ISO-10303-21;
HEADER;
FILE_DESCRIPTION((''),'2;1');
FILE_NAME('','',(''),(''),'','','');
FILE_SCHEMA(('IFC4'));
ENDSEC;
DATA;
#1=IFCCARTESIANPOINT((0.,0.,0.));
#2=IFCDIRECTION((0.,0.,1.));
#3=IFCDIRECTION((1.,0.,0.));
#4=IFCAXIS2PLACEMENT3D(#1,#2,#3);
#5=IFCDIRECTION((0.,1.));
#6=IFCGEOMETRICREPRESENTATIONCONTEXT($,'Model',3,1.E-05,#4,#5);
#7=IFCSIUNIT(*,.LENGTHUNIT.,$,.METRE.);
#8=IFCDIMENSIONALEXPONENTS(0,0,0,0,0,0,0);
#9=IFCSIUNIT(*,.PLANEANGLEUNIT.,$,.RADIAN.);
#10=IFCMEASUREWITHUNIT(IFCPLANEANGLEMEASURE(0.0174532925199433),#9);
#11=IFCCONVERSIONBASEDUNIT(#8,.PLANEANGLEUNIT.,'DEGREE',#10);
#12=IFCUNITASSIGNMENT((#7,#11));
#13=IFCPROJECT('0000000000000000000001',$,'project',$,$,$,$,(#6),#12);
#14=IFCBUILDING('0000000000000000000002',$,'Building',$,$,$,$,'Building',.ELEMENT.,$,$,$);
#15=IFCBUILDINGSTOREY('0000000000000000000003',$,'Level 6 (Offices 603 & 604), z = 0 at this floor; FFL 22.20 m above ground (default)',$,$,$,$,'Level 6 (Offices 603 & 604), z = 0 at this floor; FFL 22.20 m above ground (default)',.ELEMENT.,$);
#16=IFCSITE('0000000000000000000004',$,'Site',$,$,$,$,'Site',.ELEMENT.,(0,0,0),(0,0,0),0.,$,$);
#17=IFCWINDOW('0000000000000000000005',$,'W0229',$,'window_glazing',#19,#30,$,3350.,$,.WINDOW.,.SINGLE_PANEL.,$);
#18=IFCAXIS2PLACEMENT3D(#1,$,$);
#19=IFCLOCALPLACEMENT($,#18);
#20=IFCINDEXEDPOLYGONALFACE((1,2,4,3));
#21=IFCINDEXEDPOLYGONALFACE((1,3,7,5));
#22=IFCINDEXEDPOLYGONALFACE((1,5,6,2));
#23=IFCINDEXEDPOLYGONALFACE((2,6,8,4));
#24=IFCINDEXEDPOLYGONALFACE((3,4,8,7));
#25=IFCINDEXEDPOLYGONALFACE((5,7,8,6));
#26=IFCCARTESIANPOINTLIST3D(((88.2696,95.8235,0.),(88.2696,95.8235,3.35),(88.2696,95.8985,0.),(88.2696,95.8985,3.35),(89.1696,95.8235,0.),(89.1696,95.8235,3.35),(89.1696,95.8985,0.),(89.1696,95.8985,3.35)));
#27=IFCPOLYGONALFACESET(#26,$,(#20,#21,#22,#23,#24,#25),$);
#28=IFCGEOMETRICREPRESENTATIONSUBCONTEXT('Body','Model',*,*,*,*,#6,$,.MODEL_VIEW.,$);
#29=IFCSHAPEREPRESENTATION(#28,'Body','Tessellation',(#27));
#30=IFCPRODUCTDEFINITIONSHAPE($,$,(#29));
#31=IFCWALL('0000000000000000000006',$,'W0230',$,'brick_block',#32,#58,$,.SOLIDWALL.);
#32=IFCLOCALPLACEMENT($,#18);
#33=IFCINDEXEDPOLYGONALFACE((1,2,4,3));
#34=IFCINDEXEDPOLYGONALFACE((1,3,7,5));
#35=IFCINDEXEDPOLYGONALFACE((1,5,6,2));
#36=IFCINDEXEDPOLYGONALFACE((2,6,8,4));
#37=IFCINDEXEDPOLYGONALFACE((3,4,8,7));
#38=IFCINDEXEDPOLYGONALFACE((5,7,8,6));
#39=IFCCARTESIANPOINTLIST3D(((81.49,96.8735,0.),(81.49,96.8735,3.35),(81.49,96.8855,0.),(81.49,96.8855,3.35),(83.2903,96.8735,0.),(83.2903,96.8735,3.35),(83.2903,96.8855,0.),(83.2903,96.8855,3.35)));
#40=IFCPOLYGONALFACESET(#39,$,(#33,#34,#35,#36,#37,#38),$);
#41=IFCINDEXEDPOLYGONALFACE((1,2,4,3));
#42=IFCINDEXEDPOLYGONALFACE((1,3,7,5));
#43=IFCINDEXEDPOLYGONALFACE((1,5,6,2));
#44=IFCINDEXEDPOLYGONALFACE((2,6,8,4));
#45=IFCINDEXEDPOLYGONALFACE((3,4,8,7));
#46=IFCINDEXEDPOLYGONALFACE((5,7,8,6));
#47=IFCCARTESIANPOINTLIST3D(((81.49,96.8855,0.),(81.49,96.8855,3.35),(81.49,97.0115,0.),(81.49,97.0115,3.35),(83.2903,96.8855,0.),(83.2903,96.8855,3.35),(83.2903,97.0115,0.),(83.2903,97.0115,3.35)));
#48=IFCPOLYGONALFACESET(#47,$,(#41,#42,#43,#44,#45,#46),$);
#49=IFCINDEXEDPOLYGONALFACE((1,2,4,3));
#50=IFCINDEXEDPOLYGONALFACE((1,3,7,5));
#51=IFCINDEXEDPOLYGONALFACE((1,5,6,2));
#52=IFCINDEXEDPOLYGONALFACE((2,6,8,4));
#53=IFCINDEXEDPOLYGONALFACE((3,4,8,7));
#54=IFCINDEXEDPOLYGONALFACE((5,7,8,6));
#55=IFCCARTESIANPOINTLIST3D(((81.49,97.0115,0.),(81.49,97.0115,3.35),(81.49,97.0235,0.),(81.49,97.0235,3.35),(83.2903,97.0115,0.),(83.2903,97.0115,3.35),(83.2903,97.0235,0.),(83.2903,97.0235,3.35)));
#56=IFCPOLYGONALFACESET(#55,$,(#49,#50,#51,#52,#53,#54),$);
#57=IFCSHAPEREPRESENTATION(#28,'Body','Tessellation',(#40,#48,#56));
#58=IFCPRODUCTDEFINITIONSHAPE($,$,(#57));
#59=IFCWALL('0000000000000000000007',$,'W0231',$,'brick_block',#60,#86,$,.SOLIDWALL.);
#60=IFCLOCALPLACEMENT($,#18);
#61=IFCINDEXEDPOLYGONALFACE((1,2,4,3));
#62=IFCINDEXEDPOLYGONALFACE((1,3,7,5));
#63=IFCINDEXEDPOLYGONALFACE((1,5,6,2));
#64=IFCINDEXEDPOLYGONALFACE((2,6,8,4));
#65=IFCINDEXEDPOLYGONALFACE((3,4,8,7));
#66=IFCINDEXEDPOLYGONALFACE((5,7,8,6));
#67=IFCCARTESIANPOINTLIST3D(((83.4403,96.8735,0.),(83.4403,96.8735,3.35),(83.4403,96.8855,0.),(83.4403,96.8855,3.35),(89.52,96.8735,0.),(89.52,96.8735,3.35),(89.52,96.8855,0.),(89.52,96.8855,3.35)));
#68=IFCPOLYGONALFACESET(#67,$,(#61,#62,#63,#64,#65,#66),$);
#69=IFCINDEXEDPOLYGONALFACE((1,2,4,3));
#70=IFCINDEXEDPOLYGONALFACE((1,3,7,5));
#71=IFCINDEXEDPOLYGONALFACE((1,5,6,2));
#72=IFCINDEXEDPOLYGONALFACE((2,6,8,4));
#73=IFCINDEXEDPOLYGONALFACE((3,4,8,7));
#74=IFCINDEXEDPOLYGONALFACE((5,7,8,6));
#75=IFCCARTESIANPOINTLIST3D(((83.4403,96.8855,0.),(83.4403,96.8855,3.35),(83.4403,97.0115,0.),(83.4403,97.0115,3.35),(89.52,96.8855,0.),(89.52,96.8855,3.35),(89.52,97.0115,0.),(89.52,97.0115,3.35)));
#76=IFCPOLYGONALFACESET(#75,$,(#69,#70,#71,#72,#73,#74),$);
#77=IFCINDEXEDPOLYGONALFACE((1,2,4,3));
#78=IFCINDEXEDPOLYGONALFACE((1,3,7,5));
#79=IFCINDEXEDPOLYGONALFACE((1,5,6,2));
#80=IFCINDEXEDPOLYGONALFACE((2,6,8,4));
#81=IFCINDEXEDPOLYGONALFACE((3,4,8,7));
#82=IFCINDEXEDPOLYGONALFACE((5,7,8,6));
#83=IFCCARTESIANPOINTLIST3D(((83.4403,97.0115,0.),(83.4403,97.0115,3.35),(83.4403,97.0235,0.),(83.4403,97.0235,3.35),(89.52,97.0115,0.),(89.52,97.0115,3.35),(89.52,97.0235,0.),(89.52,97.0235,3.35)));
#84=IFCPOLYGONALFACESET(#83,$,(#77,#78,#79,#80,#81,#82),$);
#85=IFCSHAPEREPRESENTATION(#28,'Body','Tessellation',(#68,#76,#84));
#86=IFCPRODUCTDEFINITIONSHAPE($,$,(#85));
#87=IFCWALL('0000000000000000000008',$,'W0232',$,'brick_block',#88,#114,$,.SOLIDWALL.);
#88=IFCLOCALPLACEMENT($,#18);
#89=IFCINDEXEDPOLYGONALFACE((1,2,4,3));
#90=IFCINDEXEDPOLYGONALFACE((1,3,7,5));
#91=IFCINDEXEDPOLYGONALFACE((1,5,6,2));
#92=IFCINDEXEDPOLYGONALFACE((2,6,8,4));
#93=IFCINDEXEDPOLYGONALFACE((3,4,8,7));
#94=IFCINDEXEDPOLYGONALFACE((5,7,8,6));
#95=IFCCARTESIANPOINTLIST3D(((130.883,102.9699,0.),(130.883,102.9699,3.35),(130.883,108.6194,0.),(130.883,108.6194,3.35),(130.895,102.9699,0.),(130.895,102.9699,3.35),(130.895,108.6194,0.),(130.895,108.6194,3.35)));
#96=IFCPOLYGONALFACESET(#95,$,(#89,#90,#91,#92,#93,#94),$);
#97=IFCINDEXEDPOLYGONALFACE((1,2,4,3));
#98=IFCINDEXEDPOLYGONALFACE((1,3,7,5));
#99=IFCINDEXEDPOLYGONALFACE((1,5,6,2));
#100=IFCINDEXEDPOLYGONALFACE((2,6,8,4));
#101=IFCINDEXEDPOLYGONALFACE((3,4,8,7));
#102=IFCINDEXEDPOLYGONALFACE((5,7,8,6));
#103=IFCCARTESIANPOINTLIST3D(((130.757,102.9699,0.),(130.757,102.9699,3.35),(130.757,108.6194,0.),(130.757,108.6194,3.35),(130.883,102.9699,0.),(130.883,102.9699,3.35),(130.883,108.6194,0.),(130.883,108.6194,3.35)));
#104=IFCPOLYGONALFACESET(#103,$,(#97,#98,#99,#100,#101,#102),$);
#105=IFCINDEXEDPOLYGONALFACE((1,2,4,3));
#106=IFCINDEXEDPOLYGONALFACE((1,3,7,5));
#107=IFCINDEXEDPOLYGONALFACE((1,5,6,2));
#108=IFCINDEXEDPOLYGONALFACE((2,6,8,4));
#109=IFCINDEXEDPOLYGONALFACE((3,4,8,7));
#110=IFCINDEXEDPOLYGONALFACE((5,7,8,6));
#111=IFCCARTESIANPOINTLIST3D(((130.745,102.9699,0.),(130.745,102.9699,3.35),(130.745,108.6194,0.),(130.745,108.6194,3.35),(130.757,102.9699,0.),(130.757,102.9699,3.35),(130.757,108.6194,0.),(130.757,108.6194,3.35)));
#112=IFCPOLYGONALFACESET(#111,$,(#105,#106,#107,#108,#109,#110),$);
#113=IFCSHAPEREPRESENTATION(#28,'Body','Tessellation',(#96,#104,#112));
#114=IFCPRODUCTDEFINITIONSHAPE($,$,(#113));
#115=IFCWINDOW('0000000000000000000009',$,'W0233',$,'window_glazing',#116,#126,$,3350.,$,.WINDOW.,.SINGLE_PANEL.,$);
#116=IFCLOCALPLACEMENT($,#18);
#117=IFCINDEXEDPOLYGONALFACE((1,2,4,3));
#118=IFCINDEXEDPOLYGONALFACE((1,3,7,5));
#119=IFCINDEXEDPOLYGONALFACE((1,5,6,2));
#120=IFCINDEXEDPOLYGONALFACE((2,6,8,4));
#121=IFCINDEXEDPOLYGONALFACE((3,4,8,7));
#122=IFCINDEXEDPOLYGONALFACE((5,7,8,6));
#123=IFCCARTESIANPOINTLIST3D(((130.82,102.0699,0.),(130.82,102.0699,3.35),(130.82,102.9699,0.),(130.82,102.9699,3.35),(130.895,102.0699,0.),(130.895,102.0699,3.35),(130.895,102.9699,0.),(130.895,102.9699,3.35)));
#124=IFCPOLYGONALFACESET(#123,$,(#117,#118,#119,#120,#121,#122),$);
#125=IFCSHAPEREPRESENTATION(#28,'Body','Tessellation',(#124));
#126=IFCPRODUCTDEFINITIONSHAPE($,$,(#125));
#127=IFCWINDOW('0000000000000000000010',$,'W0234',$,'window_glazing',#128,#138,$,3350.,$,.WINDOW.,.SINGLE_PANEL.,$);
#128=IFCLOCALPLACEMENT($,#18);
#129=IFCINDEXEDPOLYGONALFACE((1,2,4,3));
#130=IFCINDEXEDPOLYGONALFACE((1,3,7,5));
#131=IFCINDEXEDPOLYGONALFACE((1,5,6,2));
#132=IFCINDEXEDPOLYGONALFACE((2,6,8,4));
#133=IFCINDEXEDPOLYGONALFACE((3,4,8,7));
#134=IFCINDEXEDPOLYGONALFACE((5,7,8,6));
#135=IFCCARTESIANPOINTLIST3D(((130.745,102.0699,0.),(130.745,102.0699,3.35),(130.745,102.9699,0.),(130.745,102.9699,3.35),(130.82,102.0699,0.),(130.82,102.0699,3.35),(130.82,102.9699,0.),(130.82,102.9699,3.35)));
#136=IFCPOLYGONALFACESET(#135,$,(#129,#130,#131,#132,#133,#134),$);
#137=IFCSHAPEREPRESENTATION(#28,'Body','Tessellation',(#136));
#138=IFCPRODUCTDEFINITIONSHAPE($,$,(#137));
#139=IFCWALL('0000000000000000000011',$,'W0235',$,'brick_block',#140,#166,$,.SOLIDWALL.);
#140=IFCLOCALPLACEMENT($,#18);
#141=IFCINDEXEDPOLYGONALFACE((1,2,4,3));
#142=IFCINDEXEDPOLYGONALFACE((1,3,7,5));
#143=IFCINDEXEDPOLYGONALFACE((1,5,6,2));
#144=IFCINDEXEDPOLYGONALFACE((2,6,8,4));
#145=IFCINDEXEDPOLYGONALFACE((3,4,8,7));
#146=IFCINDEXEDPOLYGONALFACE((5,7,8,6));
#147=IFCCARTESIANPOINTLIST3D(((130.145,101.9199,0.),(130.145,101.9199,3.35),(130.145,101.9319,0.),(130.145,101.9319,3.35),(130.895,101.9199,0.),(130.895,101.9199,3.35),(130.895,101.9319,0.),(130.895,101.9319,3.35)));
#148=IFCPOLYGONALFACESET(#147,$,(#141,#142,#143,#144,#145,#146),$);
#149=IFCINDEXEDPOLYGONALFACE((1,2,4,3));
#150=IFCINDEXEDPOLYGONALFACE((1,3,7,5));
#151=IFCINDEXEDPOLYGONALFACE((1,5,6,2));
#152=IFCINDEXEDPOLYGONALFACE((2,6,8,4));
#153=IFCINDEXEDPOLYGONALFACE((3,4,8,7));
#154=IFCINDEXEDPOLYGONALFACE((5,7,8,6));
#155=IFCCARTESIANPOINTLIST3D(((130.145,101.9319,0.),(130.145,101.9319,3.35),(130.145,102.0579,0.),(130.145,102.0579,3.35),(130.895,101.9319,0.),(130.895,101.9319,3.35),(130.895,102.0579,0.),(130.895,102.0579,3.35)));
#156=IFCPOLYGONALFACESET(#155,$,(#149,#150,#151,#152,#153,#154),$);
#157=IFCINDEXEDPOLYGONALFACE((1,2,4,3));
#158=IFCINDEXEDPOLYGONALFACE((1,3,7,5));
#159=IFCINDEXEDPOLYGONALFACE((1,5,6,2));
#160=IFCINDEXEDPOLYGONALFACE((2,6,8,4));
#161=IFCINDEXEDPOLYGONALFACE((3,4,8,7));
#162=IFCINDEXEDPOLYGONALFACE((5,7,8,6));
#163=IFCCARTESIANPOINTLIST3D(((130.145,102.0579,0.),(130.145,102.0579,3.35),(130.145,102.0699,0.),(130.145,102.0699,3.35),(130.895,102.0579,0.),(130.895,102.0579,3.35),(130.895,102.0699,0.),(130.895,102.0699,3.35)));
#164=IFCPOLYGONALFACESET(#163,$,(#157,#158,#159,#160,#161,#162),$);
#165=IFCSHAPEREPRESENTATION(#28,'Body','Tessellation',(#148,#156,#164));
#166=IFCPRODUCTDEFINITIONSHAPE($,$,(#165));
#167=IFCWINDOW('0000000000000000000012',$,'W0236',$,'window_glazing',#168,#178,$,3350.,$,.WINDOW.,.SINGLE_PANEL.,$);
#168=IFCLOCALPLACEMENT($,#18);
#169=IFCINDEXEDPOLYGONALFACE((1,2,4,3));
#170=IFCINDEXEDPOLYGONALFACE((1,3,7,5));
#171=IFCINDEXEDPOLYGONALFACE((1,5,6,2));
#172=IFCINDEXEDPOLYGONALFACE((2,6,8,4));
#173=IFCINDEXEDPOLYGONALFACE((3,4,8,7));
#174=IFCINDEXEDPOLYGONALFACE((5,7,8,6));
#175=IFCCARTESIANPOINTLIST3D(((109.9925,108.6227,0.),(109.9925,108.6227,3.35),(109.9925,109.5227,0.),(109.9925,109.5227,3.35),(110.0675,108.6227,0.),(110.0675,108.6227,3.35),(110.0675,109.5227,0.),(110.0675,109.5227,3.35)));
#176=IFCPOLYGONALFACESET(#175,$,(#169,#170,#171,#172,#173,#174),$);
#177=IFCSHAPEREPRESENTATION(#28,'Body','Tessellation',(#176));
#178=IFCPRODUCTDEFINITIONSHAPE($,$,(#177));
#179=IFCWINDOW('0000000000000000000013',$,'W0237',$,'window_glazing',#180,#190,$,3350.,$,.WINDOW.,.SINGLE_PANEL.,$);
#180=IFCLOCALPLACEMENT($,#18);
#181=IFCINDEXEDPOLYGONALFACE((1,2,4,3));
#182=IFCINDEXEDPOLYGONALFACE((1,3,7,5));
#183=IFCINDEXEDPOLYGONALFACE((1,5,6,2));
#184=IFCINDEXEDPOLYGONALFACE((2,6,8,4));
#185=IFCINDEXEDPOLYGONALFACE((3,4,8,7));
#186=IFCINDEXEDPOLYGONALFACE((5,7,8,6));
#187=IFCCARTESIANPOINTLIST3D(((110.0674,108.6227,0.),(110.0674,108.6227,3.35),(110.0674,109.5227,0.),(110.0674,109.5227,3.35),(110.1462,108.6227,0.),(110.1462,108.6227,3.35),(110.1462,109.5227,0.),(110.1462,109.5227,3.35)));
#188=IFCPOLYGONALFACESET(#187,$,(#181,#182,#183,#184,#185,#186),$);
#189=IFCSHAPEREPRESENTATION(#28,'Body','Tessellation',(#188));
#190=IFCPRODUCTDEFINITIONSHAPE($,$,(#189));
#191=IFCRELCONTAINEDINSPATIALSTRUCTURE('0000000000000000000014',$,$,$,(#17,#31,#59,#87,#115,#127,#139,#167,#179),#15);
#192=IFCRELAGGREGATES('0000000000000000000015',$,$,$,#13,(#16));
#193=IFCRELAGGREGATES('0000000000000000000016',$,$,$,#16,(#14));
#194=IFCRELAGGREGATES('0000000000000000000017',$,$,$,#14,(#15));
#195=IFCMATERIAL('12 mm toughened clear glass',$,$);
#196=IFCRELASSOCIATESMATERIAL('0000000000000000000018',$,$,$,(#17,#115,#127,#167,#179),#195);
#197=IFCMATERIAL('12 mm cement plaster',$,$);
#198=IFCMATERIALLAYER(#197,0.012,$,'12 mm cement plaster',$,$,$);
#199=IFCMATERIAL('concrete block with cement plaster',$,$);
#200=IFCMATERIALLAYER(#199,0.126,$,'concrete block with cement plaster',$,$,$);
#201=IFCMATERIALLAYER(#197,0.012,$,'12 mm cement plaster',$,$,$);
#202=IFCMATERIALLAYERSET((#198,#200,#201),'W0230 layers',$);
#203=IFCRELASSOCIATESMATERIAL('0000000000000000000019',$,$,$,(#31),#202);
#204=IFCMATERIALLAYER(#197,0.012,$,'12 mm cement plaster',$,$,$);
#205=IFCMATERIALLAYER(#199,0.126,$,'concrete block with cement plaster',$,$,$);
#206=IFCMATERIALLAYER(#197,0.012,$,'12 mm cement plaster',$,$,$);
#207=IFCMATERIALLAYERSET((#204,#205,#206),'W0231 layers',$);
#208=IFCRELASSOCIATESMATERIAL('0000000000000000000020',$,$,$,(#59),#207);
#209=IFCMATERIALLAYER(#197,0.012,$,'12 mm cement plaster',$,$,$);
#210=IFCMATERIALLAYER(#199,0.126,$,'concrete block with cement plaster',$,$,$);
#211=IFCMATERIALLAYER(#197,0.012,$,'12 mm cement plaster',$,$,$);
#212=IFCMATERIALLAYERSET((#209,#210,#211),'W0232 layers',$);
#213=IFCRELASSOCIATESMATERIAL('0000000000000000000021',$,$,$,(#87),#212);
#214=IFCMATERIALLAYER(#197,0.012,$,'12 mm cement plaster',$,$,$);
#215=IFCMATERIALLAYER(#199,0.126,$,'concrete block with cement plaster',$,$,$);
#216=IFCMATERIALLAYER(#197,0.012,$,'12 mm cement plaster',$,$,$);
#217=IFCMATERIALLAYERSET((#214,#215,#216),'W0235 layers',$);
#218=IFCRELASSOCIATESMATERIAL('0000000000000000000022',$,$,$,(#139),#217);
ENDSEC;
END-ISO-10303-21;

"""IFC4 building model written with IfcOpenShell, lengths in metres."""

from ifc_helpers import new_model, entity, si_unit, converted_unit, direction, frame, frame_2d, origin_with_axes, origin_2d_with_axis, place, context, subcontext, project, spatial, rectangle, extrude, material, layer, layer_set, layer_usage, element, save


model = new_model("IFC4")

# Units and contexts
model_context = context("Model", 3, precision=1e-05, world=origin_with_axes(), true_north=direction((0.0, 1.0)))
body_context = subcontext(model_context, "Body", "Model", "MODEL_VIEW")
ifc_project = project(units=[si_unit("LENGTHUNIT", "METRE"), converted_unit("PLANEANGLEUNIT", "DEGREE", entity("IfcPlaneAngleMeasure", 0.0174532925199433), si_unit("PLANEANGLEUNIT", "RADIAN"), dimensions=[0, 0, 0, 0, 0, 0, 0])], contexts=[model_context])

# Site, building, storey
site = spatial("IfcSite", under=ifc_project, Name="Site", LongName="Site", CompositionType="ELEMENT", RefLatitude=(0, 0, 0), RefLongitude=(0, 0, 0), RefElevation=0.0)
building = spatial("IfcBuilding", under=site, Name="Building", LongName="Building", CompositionType="ELEMENT")
storey = spatial("IfcBuildingStorey", under=building, Name="Level 6 (Offices 603 & 604), z = 0 at this floor; FFL 22.20 m above ground (default)", LongName="Level 6 (Offices 603 & 604), z = 0 at this floor; FFL 22.20 m above ground (default)", CompositionType="ELEMENT")

# Shared definitions
ifc_material_1 = material(Name="12 mm toughened clear glass")
placement = place(None, origin_with_axes())

# Shared definitions
ifc_material_2 = material(Name="12 mm cement plaster")
ifc_material_3 = material(Name="concrete block with cement plaster")

# Window
element("IfcWindow", 1, at=placement, inside=storey, material=ifc_material_1, Name="W0229", ObjectType="window_glazing", OverallHeight=3350.0, PartitioningType="SINGLE_PANEL", PredefinedType="WINDOW", context=body_context, shape_type="SweptSolid", body=[
    extrude(rectangle(XDim=0.9, YDim=0.075, at=frame_2d((0.0, 0.0), x_axis=(1.0, 0.0))), frame((88.7196, 95.861, 0.0), z_axis=(0.0, 0.0, 1.0), x_axis=(1.0, 0.0, 0.0)), (0.0, 0.0, 1.0), 3.35),
])

# Walls
ifc_layer_1 = layer(ifc_material_2, 0.012, Name="12 mm cement plaster")
ifc_layer_2 = layer(ifc_material_3, 0.126, Name="concrete block with cement plaster")
ifc_layer_3 = layer(ifc_material_2, 0.012, Name="12 mm cement plaster")
ifc_layer_set_1 = layer_set([ifc_layer_1, ifc_layer_2, ifc_layer_3], Name="W0230 layers")
ifc_layer_usage_1 = layer_usage(ifc_layer_set_1, "AXIS2", "POSITIVE", -0.075)
element("IfcWall", 2, at=placement, inside=storey, material=ifc_layer_usage_1, Name="W0230", ObjectType="brick_block", PredefinedType="SOLIDWALL", context=body_context, shape_type="SweptSolid", body=[
    extrude(rectangle(XDim=1.8003, YDim=0.012, at=frame_2d((0.0, 0.0), x_axis=(1.0, 0.0))), frame((82.3902, 96.8795, 0.0), z_axis=(0.0, 0.0, 1.0), x_axis=(1.0, 0.0, 0.0)), (0.0, 0.0, 1.0), 3.35),
    extrude(rectangle(XDim=1.8003, YDim=0.126, at=frame_2d((0.0, 0.069), x_axis=(1.0, 0.0))), frame((82.3902, 96.8795, 0.0), z_axis=(0.0, 0.0, 1.0), x_axis=(1.0, 0.0, 0.0)), (0.0, 0.0, 1.0), 3.35),
    extrude(rectangle(XDim=1.8003, YDim=0.012, at=frame_2d((0.0, 0.138), x_axis=(1.0, 0.0))), frame((82.3902, 96.8795, 0.0), z_axis=(0.0, 0.0, 1.0), x_axis=(1.0, 0.0, 0.0)), (0.0, 0.0, 1.0), 3.35),
])
ifc_layer_4 = layer(ifc_material_2, 0.012, Name="12 mm cement plaster")
ifc_layer_5 = layer(ifc_material_3, 0.126, Name="concrete block with cement plaster")
ifc_layer_6 = layer(ifc_material_2, 0.012, Name="12 mm cement plaster")
ifc_layer_set_2 = layer_set([ifc_layer_4, ifc_layer_5, ifc_layer_6], Name="W0231 layers")
ifc_layer_usage_2 = layer_usage(ifc_layer_set_2, "AXIS2", "POSITIVE", -0.075)
element("IfcWall", 3, at=placement, inside=storey, material=ifc_layer_usage_2, Name="W0231", ObjectType="brick_block", PredefinedType="SOLIDWALL", context=body_context, shape_type="SweptSolid", body=[
    extrude(rectangle(XDim=6.0797, YDim=0.012, at=origin_2d_with_axis()), frame((86.4801, 96.8795, 0.0), z_axis=(0.0, 0.0, 1.0), x_axis=(1.0, 0.0, 0.0)), (0.0, 0.0, 1.0), 3.35),
    extrude(rectangle(XDim=6.0797, YDim=0.126, at=frame_2d((0.0, 0.069), x_axis=(1.0, 0.0))), frame((86.4801, 96.8795, 0.0), z_axis=(0.0, 0.0, 1.0), x_axis=(1.0, 0.0, 0.0)), (0.0, 0.0, 1.0), 3.35),
    extrude(rectangle(XDim=6.0797, YDim=0.012, at=frame_2d((0.0, 0.138), x_axis=(1.0, 0.0))), frame((86.4801, 96.8795, 0.0), z_axis=(0.0, 0.0, 1.0), x_axis=(1.0, 0.0, 0.0)), (0.0, 0.0, 1.0), 3.35),
])
ifc_layer_7 = layer(ifc_material_2, 0.012, Name="12 mm cement plaster")
ifc_layer_8 = layer(ifc_material_3, 0.126, Name="concrete block with cement plaster")
ifc_layer_9 = layer(ifc_material_2, 0.012, Name="12 mm cement plaster")
ifc_layer_set_3 = layer_set([ifc_layer_7, ifc_layer_8, ifc_layer_9], Name="W0232 layers")
ifc_layer_usage_3 = layer_usage(ifc_layer_set_3, "AXIS2", "POSITIVE", -0.075)
element("IfcWall", 4, at=placement, inside=storey, material=ifc_layer_usage_3, Name="W0232", ObjectType="brick_block", PredefinedType="SOLIDWALL", context=body_context, shape_type="SweptSolid", body=[
    extrude(rectangle(XDim=5.6495, YDim=0.012, at=frame_2d((0.0, 0.0), x_axis=(0.0, 1.0))), frame((130.889, 105.7947, 0.0), z_axis=(0.0, 0.0, 1.0), x_axis=(1.0, 0.0, 0.0)), (0.0, 0.0, 1.0), 3.35),
    extrude(rectangle(XDim=5.6495, YDim=0.126, at=frame_2d((-0.069, 0.0), x_axis=(0.0, 1.0))), frame((130.889, 105.7947, 0.0), z_axis=(0.0, 0.0, 1.0), x_axis=(1.0, 0.0, 0.0)), (0.0, 0.0, 1.0), 3.35),
    extrude(rectangle(XDim=5.6495, YDim=0.012, at=frame_2d((-0.138, 0.0), x_axis=(0.0, 1.0))), frame((130.889, 105.7947, 0.0), z_axis=(0.0, 0.0, 1.0), x_axis=(1.0, 0.0, 0.0)), (0.0, 0.0, 1.0), 3.35),
])

# Windows
element("IfcWindow", 5, at=placement, inside=storey, material=ifc_material_1, Name="W0233", ObjectType="window_glazing", OverallHeight=3350.0, PartitioningType="SINGLE_PANEL", PredefinedType="WINDOW", context=body_context, shape_type="SweptSolid", body=[
    extrude(rectangle(XDim=0.9, YDim=0.075, at=frame_2d((0.0, 0.0), x_axis=(0.0, 1.0))), frame((130.8575, 102.5199, 0.0), z_axis=(0.0, 0.0, 1.0), x_axis=(1.0, 0.0, 0.0)), (0.0, 0.0, 1.0), 3.35),
])
element("IfcWindow", 6, at=placement, inside=storey, material=ifc_material_1, Name="W0234", ObjectType="window_glazing", OverallHeight=3350.0, PartitioningType="SINGLE_PANEL", PredefinedType="WINDOW", context=body_context, shape_type="SweptSolid", body=[
    extrude(rectangle(XDim=0.9, YDim=0.075, at=frame_2d((0.0, 0.0), x_axis=(0.0, 1.0))), frame((130.7825, 102.5199, 0.0), z_axis=(0.0, 0.0, 1.0), x_axis=(1.0, 0.0, 0.0)), (0.0, 0.0, 1.0), 3.35),
])

# Wall
ifc_layer_10 = layer(ifc_material_2, 0.012, Name="12 mm cement plaster")
ifc_layer_11 = layer(ifc_material_3, 0.126, Name="concrete block with cement plaster")
ifc_layer_12 = layer(ifc_material_2, 0.012, Name="12 mm cement plaster")
ifc_layer_set_4 = layer_set([ifc_layer_10, ifc_layer_11, ifc_layer_12], Name="W0235 layers")
ifc_layer_usage_4 = layer_usage(ifc_layer_set_4, "AXIS2", "POSITIVE", -0.075)
element("IfcWall", 7, at=placement, inside=storey, material=ifc_layer_usage_4, Name="W0235", ObjectType="brick_block", PredefinedType="SOLIDWALL", context=body_context, shape_type="SweptSolid", body=[
    extrude(rectangle(XDim=0.75, YDim=0.012, at=frame_2d((0.0, 0.0), x_axis=(1.0, 0.0))), frame((130.52, 101.9259, 0.0), z_axis=(0.0, 0.0, 1.0), x_axis=(1.0, 0.0, 0.0)), (0.0, 0.0, 1.0), 3.35),
    extrude(rectangle(XDim=0.75, YDim=0.126, at=frame_2d((0.0, 0.069), x_axis=(1.0, 0.0))), frame((130.52, 101.9259, 0.0), z_axis=(0.0, 0.0, 1.0), x_axis=(1.0, 0.0, 0.0)), (0.0, 0.0, 1.0), 3.35),
    extrude(rectangle(XDim=0.75, YDim=0.012, at=frame_2d((0.0, 0.138), x_axis=(1.0, 0.0))), frame((130.52, 101.9259, 0.0), z_axis=(0.0, 0.0, 1.0), x_axis=(1.0, 0.0, 0.0)), (0.0, 0.0, 1.0), 3.35),
])

# Windows
element("IfcWindow", 8, at=placement, inside=storey, material=ifc_material_1, Name="W0236", ObjectType="window_glazing", OverallHeight=3350.0, PartitioningType="SINGLE_PANEL", PredefinedType="WINDOW", context=body_context, shape_type="SweptSolid", body=[
    extrude(rectangle(XDim=0.9, YDim=0.075, at=frame_2d((0.0, 0.0), x_axis=(0.0, 1.0))), frame((110.03, 109.0727, 0.0), z_axis=(0.0, 0.0, 1.0), x_axis=(1.0, 0.0, 0.0)), (0.0, 0.0, 1.0), 3.35),
])
element("IfcWindow", 9, at=placement, inside=storey, material=ifc_material_1, Name="W0237", ObjectType="window_glazing", OverallHeight=3350.0, PartitioningType="SINGLE_PANEL", PredefinedType="WINDOW", context=body_context, shape_type="SweptSolid", body=[
    extrude(rectangle(XDim=0.9, YDim=0.0787, at=frame_2d((0.0, 0.0), x_axis=(0.0, 1.0))), frame((110.1068, 109.0727, 0.0), z_axis=(0.0, 0.0, 1.0), x_axis=(1.0, 0.0, 0.0)), (0.0, 0.0, 1.0), 3.35),
])

save(model, "model.ifc")
